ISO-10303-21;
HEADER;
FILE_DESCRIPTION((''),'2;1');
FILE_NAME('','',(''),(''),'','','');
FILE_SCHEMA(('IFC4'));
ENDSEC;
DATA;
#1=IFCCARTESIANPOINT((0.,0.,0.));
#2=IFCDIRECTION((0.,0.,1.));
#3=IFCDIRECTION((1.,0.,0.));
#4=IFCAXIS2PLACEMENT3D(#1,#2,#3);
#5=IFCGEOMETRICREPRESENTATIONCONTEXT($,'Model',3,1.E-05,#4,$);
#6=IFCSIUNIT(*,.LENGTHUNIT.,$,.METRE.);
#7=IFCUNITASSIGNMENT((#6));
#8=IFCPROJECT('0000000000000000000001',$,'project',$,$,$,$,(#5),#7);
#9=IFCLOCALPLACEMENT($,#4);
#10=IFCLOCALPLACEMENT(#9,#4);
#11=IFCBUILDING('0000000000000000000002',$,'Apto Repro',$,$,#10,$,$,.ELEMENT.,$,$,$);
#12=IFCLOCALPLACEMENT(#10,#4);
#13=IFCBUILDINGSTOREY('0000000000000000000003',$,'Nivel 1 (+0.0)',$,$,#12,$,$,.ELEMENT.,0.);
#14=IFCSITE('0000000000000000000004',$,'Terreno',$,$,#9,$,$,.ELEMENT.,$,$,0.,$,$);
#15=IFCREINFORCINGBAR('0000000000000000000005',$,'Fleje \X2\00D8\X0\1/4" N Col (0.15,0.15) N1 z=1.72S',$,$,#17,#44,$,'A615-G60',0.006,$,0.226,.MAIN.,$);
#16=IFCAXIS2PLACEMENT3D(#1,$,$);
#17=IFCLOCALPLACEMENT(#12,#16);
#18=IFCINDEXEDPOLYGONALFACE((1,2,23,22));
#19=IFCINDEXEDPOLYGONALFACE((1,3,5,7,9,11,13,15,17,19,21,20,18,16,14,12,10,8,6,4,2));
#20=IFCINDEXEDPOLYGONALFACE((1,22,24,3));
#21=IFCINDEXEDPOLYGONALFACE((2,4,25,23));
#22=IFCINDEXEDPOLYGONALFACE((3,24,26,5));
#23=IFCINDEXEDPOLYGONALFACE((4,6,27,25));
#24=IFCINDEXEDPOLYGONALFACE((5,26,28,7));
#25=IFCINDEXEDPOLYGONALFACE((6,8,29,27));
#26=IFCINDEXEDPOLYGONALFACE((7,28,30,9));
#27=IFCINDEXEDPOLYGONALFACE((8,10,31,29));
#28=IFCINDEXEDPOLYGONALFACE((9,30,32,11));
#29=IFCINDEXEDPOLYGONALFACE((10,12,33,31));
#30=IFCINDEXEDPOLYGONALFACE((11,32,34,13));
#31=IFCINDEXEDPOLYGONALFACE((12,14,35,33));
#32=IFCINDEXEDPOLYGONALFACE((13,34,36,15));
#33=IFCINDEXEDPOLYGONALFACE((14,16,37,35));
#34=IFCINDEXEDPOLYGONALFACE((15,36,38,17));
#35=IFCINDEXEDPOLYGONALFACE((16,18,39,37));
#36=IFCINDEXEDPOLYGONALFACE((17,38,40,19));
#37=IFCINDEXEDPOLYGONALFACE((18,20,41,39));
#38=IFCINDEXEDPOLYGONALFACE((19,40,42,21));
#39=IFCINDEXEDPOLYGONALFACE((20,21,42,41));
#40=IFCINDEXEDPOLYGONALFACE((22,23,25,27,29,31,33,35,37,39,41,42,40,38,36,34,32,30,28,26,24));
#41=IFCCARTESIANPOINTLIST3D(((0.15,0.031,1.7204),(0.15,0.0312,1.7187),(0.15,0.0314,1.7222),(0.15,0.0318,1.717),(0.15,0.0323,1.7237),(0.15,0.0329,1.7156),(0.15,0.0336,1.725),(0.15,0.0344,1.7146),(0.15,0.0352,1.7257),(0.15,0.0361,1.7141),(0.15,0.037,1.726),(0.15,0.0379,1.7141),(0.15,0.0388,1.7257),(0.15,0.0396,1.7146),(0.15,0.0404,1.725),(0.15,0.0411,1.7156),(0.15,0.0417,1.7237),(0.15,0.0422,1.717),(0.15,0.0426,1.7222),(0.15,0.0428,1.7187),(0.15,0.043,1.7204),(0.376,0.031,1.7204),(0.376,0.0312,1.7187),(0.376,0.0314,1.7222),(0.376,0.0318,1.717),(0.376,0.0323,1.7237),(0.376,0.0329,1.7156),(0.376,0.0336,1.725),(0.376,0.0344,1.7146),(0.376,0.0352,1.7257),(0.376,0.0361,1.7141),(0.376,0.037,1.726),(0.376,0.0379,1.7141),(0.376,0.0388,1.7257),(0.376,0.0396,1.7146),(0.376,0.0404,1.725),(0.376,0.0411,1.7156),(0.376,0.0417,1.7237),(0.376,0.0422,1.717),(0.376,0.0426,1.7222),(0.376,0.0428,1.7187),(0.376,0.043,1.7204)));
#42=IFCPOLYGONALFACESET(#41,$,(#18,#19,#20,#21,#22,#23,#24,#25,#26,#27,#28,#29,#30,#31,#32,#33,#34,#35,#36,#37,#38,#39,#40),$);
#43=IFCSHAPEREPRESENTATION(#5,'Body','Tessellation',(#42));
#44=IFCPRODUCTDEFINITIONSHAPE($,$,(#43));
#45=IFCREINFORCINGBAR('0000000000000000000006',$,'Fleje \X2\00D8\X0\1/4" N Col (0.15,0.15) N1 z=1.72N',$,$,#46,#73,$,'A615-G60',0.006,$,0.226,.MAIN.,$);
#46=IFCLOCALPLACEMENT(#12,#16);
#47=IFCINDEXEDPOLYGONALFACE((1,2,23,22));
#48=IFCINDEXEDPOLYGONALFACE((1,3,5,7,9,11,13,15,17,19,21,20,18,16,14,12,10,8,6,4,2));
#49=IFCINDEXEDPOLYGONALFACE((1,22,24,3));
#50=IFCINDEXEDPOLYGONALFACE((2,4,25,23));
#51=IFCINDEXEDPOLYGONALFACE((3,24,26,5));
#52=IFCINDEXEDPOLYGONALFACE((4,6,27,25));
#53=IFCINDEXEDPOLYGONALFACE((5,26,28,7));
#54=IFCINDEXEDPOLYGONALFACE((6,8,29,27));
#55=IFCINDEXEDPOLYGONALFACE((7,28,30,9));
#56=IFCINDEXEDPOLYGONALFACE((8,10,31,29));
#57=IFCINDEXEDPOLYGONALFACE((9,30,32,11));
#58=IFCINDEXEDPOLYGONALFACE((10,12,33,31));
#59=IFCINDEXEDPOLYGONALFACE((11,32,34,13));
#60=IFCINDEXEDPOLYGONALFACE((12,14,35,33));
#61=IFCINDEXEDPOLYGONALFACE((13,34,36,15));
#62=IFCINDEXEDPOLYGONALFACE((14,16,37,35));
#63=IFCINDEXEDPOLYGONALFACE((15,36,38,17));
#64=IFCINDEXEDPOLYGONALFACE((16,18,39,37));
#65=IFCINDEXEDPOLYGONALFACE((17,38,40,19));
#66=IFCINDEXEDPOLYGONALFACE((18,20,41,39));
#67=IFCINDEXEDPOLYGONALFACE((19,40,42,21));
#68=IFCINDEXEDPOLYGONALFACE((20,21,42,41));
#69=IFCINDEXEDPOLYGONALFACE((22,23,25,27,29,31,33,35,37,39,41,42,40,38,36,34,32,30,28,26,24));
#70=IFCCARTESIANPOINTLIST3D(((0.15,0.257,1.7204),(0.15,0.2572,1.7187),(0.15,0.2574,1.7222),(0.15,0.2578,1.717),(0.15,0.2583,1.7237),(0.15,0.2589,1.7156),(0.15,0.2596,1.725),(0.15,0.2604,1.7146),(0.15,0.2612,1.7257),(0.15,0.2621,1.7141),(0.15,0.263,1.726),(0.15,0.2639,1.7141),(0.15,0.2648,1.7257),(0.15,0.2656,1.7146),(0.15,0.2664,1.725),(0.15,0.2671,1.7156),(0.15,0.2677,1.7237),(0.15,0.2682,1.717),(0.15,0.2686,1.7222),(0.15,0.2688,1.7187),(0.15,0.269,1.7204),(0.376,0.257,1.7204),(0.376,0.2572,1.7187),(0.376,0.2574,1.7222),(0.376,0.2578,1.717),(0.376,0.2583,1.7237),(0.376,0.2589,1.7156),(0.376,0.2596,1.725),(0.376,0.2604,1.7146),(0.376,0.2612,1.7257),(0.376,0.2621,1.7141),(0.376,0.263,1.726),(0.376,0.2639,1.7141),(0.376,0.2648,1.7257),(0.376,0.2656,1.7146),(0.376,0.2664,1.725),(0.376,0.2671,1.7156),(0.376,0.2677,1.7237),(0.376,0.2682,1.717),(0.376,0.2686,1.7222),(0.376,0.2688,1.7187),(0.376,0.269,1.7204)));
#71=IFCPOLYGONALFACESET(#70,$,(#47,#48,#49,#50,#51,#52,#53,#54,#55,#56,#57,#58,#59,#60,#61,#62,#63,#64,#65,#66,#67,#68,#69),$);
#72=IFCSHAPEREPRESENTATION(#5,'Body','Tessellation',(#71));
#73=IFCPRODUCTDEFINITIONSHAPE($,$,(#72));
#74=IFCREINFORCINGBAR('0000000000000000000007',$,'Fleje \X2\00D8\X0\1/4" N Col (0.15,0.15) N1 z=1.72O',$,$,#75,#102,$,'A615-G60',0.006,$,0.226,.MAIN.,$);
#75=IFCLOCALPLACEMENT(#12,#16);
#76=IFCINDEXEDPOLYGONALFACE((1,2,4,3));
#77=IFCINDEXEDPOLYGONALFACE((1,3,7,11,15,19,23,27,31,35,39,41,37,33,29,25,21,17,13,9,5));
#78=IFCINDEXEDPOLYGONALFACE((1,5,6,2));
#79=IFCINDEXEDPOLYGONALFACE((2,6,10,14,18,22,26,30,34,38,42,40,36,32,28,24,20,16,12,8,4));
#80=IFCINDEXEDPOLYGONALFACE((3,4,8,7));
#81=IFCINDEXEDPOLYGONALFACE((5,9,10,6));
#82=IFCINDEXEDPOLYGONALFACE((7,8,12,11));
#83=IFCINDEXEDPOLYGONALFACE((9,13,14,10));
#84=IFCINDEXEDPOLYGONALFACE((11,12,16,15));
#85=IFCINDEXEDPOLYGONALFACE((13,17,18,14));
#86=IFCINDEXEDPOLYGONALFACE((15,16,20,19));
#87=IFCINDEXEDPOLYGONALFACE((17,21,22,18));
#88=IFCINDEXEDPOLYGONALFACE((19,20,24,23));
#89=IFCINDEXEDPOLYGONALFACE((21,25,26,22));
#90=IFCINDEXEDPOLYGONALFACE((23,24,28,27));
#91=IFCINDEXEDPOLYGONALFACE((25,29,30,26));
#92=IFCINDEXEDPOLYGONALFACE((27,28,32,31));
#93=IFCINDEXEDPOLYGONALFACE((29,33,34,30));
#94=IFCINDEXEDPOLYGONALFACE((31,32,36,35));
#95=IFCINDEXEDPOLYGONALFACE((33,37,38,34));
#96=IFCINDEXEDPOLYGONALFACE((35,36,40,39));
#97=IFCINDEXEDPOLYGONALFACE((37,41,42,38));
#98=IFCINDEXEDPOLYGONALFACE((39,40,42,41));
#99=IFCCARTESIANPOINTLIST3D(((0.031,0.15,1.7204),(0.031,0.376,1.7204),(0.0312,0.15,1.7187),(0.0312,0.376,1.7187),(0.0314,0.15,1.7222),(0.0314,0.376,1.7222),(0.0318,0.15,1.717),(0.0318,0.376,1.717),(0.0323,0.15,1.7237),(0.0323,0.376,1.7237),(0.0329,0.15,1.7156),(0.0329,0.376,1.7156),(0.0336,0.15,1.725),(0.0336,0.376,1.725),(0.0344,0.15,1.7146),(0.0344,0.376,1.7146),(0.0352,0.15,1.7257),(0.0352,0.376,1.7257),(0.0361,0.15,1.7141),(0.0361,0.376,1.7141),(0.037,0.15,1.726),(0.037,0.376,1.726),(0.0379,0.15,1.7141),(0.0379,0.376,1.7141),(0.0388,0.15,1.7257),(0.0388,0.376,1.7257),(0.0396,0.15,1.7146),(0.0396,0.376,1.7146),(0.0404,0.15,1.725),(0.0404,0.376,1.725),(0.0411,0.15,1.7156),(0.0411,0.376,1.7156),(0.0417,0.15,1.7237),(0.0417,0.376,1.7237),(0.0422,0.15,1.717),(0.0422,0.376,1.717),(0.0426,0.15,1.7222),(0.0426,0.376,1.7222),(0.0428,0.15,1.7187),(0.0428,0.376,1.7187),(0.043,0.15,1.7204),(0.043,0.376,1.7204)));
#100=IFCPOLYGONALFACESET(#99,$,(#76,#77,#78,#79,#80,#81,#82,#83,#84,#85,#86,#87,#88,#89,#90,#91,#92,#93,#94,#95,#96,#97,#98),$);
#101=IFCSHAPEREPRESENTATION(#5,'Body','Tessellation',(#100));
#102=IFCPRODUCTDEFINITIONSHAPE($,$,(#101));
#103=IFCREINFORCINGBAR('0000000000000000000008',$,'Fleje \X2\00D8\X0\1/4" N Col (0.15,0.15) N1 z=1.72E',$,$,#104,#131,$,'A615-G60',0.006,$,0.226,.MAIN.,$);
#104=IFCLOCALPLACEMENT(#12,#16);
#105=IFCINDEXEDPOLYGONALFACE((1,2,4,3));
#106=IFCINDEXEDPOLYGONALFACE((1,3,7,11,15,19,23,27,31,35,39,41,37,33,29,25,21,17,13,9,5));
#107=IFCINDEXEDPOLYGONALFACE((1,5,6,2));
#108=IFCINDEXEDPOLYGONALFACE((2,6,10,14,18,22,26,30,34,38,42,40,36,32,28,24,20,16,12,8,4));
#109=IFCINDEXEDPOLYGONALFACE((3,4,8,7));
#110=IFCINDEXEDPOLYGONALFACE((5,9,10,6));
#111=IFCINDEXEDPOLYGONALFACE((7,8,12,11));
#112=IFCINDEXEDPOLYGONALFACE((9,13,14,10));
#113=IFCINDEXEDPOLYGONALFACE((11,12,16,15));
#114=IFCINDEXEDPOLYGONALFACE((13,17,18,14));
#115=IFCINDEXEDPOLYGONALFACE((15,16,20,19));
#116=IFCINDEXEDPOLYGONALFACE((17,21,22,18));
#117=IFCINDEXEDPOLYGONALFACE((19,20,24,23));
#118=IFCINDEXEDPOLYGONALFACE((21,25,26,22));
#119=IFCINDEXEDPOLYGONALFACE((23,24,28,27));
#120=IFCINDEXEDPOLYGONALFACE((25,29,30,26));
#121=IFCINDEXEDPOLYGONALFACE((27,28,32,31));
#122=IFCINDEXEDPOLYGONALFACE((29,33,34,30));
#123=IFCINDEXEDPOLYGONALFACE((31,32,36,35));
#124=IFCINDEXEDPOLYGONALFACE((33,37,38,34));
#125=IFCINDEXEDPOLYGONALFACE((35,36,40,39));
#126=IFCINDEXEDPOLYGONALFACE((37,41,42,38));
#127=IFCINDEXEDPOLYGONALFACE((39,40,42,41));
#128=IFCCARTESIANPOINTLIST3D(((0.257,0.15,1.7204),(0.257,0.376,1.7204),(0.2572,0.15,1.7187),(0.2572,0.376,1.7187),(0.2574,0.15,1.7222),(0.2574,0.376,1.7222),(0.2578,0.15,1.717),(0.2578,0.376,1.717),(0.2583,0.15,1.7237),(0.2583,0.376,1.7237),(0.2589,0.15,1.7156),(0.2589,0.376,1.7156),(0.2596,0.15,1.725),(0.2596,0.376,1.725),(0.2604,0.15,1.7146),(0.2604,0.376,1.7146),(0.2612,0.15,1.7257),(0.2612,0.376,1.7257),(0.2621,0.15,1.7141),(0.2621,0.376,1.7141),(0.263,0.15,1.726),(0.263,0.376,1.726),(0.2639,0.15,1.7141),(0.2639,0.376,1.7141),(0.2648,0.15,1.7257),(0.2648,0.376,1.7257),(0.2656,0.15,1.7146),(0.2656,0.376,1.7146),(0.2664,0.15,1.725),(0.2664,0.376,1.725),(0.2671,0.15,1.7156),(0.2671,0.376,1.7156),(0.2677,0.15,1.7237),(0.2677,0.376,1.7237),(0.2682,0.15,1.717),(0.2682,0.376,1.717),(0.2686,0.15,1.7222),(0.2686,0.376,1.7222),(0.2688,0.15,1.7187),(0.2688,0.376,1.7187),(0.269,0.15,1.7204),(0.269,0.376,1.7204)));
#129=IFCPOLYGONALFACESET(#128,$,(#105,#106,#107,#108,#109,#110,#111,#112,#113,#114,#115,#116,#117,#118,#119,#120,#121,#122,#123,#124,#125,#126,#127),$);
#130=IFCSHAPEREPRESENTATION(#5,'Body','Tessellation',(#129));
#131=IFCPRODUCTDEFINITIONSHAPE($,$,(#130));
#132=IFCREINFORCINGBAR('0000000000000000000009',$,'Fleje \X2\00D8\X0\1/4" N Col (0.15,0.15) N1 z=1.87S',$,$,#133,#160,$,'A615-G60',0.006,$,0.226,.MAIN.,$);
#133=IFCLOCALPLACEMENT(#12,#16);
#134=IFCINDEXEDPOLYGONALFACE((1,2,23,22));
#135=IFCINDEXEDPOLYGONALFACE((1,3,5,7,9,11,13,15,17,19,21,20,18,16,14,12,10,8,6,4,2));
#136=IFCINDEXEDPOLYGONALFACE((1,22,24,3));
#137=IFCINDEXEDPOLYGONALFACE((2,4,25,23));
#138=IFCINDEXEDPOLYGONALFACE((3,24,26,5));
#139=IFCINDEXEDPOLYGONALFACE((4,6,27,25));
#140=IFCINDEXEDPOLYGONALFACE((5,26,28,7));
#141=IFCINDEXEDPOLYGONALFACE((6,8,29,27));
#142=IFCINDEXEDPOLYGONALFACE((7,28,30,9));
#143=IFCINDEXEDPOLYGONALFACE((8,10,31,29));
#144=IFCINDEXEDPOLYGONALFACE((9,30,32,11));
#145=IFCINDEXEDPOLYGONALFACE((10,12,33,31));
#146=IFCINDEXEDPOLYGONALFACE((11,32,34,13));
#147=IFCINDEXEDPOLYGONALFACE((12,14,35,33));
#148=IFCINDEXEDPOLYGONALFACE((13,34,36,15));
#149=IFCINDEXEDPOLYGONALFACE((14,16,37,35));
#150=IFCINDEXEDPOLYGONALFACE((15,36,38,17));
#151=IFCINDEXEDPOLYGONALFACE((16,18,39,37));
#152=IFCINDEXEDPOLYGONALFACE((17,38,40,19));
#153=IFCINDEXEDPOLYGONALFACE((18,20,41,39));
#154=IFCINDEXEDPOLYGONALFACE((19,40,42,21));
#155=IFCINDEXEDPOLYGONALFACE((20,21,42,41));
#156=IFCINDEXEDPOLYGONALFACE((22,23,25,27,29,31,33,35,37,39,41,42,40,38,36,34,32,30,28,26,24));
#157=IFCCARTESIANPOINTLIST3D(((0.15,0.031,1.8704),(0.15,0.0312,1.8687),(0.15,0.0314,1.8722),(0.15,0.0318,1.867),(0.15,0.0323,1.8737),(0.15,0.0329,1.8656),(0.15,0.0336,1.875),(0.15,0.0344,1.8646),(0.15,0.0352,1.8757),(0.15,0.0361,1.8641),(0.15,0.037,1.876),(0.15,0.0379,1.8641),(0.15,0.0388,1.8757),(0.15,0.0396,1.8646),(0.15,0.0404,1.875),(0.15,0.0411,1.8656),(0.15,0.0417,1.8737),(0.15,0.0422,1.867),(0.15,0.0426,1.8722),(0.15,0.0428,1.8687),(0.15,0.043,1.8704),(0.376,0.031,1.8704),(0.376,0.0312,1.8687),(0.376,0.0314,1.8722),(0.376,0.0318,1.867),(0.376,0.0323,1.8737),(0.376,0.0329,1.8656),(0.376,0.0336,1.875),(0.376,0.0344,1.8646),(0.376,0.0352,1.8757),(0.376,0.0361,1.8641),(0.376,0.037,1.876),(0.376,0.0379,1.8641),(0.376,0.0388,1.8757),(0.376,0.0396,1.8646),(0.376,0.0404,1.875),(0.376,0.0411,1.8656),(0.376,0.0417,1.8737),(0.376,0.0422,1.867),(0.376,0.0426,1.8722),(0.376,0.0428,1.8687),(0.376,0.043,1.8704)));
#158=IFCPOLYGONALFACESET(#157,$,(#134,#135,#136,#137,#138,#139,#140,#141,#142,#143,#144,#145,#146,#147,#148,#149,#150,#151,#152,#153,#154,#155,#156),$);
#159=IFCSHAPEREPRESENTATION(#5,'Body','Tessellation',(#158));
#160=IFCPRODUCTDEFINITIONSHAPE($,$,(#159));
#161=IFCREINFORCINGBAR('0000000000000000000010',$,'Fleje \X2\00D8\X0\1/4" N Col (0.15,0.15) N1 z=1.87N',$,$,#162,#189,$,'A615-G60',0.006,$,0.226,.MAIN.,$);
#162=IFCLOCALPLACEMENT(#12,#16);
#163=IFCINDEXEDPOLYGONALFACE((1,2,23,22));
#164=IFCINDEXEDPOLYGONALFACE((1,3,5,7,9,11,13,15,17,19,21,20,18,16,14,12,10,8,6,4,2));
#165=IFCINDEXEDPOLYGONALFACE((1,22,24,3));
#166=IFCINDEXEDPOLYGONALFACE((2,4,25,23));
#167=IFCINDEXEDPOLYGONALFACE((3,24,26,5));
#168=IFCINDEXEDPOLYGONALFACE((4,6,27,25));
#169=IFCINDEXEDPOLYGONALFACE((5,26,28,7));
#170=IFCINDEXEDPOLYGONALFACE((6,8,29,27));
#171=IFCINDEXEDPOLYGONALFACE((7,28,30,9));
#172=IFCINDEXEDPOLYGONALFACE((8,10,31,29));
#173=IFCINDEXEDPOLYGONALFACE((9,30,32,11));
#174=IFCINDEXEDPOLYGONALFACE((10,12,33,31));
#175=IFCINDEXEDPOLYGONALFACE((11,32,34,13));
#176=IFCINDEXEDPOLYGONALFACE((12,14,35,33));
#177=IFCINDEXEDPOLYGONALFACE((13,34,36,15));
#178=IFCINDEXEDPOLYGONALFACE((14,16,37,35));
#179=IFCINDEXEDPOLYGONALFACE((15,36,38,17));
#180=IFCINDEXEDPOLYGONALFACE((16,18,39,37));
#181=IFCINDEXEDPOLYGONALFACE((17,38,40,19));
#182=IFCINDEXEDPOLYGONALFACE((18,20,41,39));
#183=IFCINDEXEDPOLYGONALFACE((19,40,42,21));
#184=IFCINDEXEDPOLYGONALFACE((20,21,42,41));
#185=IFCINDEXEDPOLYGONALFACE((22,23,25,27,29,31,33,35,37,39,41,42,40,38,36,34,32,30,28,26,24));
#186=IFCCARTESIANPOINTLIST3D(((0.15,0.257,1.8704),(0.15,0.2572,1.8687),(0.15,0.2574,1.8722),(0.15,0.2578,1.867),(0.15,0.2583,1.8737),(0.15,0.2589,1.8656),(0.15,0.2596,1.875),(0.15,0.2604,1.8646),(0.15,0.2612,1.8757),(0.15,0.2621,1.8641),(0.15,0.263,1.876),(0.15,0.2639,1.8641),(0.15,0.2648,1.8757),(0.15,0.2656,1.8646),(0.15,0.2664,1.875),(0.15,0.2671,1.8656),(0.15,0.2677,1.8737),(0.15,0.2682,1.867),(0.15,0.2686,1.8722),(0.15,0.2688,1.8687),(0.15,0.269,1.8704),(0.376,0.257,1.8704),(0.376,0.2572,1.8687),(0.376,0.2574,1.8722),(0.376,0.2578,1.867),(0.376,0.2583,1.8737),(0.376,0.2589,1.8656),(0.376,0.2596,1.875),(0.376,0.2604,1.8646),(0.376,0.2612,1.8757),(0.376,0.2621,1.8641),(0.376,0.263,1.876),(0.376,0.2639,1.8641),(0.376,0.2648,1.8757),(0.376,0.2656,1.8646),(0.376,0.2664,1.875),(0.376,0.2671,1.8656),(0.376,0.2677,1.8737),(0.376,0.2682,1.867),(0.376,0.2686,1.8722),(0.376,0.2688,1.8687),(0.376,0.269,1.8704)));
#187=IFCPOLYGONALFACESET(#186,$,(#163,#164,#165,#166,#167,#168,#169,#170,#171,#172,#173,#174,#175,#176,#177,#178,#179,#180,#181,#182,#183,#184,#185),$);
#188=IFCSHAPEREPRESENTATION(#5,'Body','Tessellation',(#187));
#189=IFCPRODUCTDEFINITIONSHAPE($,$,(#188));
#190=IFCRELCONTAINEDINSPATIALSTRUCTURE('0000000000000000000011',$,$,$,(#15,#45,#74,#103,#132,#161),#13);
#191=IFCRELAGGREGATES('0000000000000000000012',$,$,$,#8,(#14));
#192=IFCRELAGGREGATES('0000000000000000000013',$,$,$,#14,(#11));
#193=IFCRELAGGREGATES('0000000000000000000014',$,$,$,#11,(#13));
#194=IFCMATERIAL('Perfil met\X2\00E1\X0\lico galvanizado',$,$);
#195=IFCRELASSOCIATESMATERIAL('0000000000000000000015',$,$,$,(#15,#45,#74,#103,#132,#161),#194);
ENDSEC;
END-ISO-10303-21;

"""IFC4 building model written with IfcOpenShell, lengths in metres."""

from ifc_helpers import new_model, si_unit, frame, origin_with_axes, origin_2d_with_axis, place, context, project, spatial, circle, extrude, material, element, save


model = new_model("IFC4")

# Units and contexts
model_context = context("Model", 3, precision=1e-05, world=origin_with_axes())
ifc_project = project(units=[si_unit("LENGTHUNIT", "METRE")], contexts=[model_context])

# Site, building, storey
site_placement = place(None, origin_with_axes())
site = spatial("IfcSite", under=ifc_project, at=site_placement, Name="Terreno", CompositionType="ELEMENT", RefElevation=0.0)
building_placement = place(site_placement, origin_with_axes())
building = spatial("IfcBuilding", under=site, at=building_placement, Name="Apto Repro", CompositionType="ELEMENT")
storey_placement = place(building_placement, origin_with_axes())
storey = spatial("IfcBuildingStorey", under=building, at=storey_placement, Name="Nivel 1 (+0.0)", CompositionType="ELEMENT", Elevation=0.0)

# Reinforcing bars
ifc_material = material(Name="Perfil metálico galvanizado")
reinforcing_bar_1_placement = place(storey_placement, origin_with_axes())
element("IfcReinforcingBar", 1, at=reinforcing_bar_1_placement, inside=storey, material=ifc_material, Name="Fleje Ø1/4\" N Col (0.15,0.15) N1 z=1.72S", SteelGrade="A615-G60", BarLength=0.226, NominalDiameter=0.006, PredefinedType="MAIN", context=model_context, shape_type="SweptSolid", body=[
    extrude(circle(Radius=0.006, at=origin_2d_with_axis()), frame((0.15, 0.037, 1.72), z_axis=(1.0, 0.0, 0.0), x_axis=(0.0, 0.0, 1.0)), (0.0, 0.0, 1.0), 0.226),
])
reinforcing_bar_2_placement = place(storey_placement, origin_with_axes())
element("IfcReinforcingBar", 2, at=reinforcing_bar_2_placement, inside=storey, material=ifc_material, Name="Fleje Ø1/4\" N Col (0.15,0.15) N1 z=1.72N", SteelGrade="A615-G60", BarLength=0.226, NominalDiameter=0.006, PredefinedType="MAIN", context=model_context, shape_type="SweptSolid", body=[
    extrude(circle(Radius=0.006, at=origin_2d_with_axis()), frame((0.15, 0.263, 1.72), z_axis=(1.0, 0.0, 0.0), x_axis=(0.0, 0.0, 1.0)), (0.0, 0.0, 1.0), 0.226),
])
reinforcing_bar_3_placement = place(storey_placement, origin_with_axes())
element("IfcReinforcingBar", 3, at=reinforcing_bar_3_placement, inside=storey, material=ifc_material, Name="Fleje Ø1/4\" N Col (0.15,0.15) N1 z=1.72O", SteelGrade="A615-G60", BarLength=0.226, NominalDiameter=0.006, PredefinedType="MAIN", context=model_context, shape_type="SweptSolid", body=[
    extrude(circle(Radius=0.006, at=origin_2d_with_axis()), frame((0.037, 0.15, 1.72), z_axis=(0.0, 1.0, 0.0), x_axis=(0.0, 0.0, 1.0)), (0.0, 0.0, 1.0), 0.226),
])
reinforcing_bar_4_placement = place(storey_placement, origin_with_axes())
element("IfcReinforcingBar", 4, at=reinforcing_bar_4_placement, inside=storey, material=ifc_material, Name="Fleje Ø1/4\" N Col (0.15,0.15) N1 z=1.72E", SteelGrade="A615-G60", BarLength=0.226, NominalDiameter=0.006, PredefinedType="MAIN", context=model_context, shape_type="SweptSolid", body=[
    extrude(circle(Radius=0.006, at=origin_2d_with_axis()), frame((0.263, 0.15, 1.72), z_axis=(0.0, 1.0, 0.0), x_axis=(0.0, 0.0, 1.0)), (0.0, 0.0, 1.0), 0.226),
])
reinforcing_bar_5_placement = place(storey_placement, origin_with_axes())
element("IfcReinforcingBar", 5, at=reinforcing_bar_5_placement, inside=storey, material=ifc_material, Name="Fleje Ø1/4\" N Col (0.15,0.15) N1 z=1.87S", SteelGrade="A615-G60", BarLength=0.226, NominalDiameter=0.006, PredefinedType="MAIN", context=model_context, shape_type="SweptSolid", body=[
    extrude(circle(Radius=0.006, at=origin_2d_with_axis()), frame((0.15, 0.037, 1.87), z_axis=(1.0, 0.0, 0.0), x_axis=(0.0, 0.0, 1.0)), (0.0, 0.0, 1.0), 0.226),
])
reinforcing_bar_6_placement = place(storey_placement, origin_with_axes())
element("IfcReinforcingBar", 6, at=reinforcing_bar_6_placement, inside=storey, material=ifc_material, Name="Fleje Ø1/4\" N Col (0.15,0.15) N1 z=1.87N", SteelGrade="A615-G60", BarLength=0.226, NominalDiameter=0.006, PredefinedType="MAIN", context=model_context, shape_type="SweptSolid", body=[
    extrude(circle(Radius=0.006, at=origin_2d_with_axis()), frame((0.15, 0.263, 1.87), z_axis=(1.0, 0.0, 0.0), x_axis=(0.0, 0.0, 1.0)), (0.0, 0.0, 1.0), 0.226),
])

save(model, "model.ifc")
